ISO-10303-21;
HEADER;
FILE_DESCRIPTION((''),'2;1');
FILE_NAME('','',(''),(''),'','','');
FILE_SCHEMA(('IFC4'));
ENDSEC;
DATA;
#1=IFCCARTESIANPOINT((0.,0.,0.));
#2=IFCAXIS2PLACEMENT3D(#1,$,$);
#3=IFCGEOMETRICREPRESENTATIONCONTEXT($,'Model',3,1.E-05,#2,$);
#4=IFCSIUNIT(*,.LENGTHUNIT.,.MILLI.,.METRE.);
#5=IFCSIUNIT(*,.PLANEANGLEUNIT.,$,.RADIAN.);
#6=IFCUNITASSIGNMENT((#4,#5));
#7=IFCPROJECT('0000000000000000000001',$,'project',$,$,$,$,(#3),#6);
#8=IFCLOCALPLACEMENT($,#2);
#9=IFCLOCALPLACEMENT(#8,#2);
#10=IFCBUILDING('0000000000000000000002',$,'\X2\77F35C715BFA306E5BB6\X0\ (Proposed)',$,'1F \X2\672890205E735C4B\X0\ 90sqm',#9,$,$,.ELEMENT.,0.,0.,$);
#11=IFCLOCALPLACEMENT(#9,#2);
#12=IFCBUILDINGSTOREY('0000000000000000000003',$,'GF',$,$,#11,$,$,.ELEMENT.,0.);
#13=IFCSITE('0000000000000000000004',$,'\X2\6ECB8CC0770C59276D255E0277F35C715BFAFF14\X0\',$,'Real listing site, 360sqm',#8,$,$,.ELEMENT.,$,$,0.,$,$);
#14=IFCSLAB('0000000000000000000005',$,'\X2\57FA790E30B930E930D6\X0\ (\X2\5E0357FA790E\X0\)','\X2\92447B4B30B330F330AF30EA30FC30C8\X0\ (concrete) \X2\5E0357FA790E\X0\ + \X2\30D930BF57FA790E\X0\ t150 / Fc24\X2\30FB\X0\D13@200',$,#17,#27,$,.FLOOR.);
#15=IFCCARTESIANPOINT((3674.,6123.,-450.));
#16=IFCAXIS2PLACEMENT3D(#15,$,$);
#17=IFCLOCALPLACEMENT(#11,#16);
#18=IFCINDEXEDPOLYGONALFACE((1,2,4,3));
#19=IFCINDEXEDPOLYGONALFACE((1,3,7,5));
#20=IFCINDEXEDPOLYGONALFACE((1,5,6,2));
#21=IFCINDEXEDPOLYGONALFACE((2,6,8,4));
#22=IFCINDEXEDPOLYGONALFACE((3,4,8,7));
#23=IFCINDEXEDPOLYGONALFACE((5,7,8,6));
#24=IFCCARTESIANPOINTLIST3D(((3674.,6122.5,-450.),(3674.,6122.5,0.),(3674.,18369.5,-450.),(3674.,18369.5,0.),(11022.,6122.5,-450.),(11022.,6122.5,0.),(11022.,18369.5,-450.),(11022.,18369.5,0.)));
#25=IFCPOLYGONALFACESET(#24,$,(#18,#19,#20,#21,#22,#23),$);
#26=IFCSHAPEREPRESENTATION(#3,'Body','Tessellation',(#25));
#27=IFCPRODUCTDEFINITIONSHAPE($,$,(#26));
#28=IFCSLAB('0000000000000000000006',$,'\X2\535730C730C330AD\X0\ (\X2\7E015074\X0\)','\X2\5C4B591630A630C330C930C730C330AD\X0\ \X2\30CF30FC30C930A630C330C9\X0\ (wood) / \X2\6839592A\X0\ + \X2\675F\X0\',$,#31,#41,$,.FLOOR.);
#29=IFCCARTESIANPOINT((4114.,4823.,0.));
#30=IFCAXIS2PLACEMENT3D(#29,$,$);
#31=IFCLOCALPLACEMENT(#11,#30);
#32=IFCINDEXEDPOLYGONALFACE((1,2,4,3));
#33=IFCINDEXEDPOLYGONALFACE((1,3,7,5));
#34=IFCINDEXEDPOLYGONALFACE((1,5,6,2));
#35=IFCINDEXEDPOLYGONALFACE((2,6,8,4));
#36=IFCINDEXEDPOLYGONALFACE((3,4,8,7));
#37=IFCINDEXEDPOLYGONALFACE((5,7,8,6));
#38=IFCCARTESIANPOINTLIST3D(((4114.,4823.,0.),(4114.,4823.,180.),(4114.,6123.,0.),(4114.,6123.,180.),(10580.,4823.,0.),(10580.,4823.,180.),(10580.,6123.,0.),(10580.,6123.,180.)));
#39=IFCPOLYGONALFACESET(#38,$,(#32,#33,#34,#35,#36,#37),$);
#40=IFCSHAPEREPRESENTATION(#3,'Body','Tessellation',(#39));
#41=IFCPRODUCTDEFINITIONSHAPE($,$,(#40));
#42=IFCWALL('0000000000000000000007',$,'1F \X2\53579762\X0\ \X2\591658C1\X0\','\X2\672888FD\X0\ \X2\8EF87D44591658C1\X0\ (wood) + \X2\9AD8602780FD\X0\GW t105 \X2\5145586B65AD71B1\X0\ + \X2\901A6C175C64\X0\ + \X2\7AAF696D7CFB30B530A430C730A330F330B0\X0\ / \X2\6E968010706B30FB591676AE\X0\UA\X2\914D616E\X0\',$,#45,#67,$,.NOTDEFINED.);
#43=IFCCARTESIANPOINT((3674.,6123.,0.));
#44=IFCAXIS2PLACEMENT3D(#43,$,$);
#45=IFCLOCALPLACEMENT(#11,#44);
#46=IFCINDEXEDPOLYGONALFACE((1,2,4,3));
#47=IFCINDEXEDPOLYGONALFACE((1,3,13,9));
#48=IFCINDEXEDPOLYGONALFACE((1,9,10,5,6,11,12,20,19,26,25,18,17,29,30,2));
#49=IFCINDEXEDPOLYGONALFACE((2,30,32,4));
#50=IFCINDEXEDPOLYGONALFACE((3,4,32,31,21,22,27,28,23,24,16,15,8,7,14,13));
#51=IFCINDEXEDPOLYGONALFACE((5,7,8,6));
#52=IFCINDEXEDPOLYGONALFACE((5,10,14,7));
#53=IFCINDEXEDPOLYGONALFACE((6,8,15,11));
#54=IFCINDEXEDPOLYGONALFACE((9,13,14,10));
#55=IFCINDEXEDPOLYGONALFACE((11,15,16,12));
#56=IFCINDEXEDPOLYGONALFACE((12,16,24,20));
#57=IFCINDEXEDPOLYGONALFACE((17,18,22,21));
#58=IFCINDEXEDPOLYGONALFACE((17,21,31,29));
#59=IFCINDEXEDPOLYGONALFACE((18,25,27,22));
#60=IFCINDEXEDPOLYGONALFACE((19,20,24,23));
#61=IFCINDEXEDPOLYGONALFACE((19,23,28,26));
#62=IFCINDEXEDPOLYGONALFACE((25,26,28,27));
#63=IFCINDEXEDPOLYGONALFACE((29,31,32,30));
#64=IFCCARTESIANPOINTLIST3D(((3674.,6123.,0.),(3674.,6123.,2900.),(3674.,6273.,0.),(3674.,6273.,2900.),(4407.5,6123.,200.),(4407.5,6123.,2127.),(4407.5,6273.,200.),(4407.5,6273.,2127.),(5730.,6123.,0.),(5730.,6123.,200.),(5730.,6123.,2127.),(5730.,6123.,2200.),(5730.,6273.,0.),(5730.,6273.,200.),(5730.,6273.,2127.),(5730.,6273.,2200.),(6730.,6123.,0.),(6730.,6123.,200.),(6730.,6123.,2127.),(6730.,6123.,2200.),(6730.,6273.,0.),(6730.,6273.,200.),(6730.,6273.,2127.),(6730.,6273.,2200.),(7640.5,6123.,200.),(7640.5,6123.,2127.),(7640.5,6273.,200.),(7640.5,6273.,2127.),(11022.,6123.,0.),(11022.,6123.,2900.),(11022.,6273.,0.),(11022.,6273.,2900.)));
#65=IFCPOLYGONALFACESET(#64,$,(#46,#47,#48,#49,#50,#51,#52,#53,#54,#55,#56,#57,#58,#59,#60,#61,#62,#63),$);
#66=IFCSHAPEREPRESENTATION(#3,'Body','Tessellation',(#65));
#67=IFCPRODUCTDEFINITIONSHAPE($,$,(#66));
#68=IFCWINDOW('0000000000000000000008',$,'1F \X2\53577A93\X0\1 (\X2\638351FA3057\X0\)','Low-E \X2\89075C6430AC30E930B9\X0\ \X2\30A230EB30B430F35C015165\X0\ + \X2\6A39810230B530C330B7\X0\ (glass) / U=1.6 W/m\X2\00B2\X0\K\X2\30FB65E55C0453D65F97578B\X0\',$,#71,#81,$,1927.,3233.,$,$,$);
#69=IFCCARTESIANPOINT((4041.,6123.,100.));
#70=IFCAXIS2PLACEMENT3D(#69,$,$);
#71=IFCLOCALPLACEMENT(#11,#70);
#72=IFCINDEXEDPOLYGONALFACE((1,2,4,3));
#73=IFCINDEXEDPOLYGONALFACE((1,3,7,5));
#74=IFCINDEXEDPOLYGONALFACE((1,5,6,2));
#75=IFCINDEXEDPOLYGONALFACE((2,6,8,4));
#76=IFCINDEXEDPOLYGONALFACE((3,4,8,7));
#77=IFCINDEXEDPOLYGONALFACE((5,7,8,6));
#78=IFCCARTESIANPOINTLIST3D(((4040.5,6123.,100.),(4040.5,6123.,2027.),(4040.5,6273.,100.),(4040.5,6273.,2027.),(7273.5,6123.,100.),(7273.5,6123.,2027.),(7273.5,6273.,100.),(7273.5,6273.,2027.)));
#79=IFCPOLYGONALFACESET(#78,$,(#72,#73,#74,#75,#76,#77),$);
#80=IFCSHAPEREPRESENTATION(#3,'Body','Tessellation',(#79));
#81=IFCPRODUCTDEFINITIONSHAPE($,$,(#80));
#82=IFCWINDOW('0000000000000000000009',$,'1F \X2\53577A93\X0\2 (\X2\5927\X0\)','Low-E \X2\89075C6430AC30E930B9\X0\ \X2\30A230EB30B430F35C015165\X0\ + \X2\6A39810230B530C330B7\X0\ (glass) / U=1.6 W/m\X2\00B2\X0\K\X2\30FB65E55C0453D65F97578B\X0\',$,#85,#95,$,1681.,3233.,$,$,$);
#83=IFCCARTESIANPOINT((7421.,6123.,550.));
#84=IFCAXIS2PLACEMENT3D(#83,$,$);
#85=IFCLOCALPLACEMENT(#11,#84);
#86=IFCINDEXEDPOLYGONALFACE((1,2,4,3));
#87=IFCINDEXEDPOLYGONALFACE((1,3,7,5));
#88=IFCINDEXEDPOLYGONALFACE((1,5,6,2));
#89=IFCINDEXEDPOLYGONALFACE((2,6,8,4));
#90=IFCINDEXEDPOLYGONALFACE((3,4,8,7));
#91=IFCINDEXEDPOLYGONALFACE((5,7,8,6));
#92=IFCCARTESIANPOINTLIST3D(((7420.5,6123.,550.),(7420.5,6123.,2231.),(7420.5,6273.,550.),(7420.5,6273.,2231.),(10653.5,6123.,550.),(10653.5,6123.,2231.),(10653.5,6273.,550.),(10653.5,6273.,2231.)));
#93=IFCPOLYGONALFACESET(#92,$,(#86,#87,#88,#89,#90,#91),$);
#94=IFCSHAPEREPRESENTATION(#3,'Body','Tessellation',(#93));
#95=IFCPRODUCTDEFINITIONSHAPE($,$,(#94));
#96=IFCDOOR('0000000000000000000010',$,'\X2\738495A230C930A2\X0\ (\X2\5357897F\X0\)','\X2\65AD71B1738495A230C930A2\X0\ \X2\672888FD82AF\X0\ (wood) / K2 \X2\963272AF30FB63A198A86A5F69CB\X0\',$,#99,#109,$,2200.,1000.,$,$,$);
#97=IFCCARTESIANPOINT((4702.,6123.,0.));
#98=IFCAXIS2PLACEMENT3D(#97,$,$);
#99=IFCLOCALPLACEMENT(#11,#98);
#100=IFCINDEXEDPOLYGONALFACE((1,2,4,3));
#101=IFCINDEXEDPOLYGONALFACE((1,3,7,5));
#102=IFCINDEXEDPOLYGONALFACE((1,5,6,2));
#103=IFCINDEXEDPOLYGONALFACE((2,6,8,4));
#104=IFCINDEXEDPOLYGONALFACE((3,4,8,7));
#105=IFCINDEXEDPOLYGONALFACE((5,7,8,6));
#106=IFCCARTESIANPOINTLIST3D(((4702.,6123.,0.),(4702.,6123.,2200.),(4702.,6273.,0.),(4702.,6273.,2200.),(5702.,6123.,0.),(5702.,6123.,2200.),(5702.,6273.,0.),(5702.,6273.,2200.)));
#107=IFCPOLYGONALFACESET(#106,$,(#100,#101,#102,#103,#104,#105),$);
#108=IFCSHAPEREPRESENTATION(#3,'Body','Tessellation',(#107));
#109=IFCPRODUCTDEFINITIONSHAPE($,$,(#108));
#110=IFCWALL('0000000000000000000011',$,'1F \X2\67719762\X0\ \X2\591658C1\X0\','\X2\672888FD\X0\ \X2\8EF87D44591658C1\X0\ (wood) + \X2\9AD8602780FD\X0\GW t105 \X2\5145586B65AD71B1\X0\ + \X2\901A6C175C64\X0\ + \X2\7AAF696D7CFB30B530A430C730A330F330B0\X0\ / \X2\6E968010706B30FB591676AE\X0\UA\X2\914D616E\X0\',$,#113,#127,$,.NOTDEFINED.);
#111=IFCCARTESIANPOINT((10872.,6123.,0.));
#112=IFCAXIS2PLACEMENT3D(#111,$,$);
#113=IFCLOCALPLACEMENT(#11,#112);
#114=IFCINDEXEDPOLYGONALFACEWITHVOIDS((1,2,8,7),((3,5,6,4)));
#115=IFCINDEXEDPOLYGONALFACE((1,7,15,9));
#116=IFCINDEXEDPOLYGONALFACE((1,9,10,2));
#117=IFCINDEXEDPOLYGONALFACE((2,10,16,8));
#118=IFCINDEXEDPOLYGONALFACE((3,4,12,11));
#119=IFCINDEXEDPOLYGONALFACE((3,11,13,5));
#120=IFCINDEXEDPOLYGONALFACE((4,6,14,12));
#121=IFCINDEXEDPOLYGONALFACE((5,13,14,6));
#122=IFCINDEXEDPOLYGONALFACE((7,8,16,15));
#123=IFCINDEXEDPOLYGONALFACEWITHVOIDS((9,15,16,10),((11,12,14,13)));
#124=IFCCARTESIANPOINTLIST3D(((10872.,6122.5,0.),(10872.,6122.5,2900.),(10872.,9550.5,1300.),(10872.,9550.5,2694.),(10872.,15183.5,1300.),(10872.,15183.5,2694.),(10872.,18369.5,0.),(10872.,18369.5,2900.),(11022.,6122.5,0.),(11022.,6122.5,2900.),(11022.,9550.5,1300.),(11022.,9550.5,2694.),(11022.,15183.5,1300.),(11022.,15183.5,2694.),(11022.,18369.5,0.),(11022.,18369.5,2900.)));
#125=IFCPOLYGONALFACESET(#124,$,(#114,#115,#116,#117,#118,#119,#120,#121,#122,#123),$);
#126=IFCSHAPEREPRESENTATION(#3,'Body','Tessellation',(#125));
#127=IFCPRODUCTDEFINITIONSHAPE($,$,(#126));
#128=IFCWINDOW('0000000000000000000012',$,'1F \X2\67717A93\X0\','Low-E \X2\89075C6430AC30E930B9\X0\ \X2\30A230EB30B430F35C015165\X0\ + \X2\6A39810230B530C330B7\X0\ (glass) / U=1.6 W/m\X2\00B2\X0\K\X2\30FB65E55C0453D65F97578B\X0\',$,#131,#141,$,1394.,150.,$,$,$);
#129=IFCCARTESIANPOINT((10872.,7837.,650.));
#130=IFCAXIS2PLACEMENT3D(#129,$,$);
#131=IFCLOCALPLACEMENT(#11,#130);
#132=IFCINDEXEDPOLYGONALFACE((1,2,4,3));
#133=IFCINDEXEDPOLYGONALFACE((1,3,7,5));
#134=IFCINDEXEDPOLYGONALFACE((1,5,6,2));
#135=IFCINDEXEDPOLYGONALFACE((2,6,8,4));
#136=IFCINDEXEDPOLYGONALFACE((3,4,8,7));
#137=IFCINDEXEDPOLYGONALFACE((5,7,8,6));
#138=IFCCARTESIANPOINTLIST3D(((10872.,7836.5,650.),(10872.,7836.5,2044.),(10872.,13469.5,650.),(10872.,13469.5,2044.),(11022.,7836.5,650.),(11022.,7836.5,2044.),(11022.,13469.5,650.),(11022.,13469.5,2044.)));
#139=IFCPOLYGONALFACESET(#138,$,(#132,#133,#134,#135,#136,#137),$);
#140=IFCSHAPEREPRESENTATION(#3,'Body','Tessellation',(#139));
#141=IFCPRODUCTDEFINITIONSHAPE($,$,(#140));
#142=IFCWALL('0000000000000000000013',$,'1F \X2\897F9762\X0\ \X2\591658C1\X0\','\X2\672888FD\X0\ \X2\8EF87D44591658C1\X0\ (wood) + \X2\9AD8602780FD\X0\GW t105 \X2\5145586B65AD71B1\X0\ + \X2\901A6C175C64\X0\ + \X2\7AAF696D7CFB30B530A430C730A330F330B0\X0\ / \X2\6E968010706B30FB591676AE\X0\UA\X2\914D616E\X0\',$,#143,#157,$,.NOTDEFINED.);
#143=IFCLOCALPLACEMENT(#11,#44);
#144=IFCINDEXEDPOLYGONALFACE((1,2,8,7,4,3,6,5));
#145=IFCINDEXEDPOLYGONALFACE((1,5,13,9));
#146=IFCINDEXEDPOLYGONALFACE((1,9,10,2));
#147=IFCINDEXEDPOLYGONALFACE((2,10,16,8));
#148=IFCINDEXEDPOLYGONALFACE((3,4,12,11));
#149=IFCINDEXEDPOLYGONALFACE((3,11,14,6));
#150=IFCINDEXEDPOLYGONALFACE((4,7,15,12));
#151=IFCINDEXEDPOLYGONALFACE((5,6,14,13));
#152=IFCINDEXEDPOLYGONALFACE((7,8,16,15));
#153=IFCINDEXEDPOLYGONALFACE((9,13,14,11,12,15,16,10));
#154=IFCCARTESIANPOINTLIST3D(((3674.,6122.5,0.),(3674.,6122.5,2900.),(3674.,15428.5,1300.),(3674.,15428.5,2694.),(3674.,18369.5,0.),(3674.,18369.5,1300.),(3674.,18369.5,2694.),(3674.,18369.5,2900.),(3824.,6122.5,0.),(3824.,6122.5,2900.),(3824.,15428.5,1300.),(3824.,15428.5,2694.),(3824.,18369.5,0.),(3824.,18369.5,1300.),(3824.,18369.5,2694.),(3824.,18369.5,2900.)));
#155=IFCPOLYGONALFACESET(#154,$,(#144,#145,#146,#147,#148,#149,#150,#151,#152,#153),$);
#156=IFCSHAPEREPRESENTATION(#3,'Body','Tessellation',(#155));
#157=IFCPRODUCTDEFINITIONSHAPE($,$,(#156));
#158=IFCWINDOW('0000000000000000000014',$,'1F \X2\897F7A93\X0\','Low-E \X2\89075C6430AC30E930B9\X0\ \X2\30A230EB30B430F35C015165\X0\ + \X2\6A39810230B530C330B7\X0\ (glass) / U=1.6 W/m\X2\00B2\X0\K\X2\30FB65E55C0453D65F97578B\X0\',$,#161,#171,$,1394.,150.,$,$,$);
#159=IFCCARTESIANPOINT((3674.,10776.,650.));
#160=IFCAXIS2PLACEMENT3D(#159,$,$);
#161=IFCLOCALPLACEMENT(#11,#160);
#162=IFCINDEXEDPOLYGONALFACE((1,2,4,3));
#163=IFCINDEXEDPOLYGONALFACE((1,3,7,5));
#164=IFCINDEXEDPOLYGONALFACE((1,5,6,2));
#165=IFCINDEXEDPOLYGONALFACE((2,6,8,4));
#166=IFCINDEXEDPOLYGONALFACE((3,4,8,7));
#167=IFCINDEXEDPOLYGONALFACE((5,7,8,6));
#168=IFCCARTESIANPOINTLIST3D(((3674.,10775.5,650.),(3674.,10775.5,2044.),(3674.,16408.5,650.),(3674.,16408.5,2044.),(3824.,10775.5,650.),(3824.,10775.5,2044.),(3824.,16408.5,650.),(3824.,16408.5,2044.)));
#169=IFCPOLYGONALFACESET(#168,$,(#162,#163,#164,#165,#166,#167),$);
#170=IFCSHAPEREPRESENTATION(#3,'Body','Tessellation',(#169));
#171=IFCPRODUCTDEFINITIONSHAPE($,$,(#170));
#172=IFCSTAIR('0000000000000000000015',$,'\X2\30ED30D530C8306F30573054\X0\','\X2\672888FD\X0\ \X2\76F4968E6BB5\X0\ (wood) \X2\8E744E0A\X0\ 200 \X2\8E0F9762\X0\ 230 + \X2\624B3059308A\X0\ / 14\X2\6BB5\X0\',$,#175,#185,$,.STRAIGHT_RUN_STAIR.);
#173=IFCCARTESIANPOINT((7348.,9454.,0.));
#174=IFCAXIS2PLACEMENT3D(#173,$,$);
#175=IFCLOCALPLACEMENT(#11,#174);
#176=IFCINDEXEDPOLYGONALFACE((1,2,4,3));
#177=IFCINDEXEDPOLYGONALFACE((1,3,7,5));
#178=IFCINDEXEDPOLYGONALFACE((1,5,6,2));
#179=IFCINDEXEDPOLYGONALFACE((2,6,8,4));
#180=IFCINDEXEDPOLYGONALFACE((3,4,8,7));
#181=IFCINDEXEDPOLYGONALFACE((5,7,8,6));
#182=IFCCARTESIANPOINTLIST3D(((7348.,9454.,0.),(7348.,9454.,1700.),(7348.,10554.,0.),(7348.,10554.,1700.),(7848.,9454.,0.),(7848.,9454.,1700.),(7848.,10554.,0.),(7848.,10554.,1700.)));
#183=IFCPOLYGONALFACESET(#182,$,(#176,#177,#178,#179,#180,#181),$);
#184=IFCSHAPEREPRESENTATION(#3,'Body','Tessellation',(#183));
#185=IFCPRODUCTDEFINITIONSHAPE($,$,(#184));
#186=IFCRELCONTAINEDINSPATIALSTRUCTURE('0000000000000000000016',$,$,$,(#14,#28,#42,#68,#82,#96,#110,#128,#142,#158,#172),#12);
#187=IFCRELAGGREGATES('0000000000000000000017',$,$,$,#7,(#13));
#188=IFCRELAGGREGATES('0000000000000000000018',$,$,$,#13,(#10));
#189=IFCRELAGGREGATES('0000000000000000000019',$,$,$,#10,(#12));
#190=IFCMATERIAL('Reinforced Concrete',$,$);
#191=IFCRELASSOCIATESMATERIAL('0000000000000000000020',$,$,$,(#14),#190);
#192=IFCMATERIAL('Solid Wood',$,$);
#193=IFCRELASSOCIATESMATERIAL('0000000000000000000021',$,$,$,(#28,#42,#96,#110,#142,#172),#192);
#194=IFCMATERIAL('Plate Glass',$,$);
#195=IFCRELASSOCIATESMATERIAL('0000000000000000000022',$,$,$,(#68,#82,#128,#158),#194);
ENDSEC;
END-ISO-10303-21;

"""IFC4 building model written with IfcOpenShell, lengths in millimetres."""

from ifc_helpers import new_model, si_unit, frame, frame_2d, origin, place, context, project, spatial, rectangle, extrude, material, element, fill, save


model = new_model("IFC4")

# Units and contexts
model_context = context("Model", 3, precision=1e-05, world=origin())
ifc_project = project(units=[si_unit("LENGTHUNIT", "METRE", prefix="MILLI"), si_unit("PLANEANGLEUNIT", "RADIAN")], contexts=[model_context])

# Site, building, storey
site_placement = place(None, origin())
site = spatial("IfcSite", under=ifc_project, at=site_placement, Name="滋賀県大津市石山寺４", ObjectType="Real listing site, 360sqm", CompositionType="ELEMENT", RefElevation=0.0)
building_placement = place(site_placement, origin())
building = spatial("IfcBuilding", under=site, at=building_placement, Name="石山寺の家 (Proposed)", ObjectType="1F 木造平屋 90sqm", CompositionType="ELEMENT", ElevationOfRefHeight=0.0, ElevationOfTerrain=0.0)
storey_placement = place(building_placement, origin())
storey = spatial("IfcBuildingStorey", under=building, at=storey_placement, Name="GF", CompositionType="ELEMENT", Elevation=0.0)

# Slabs
ifc_material_1 = material(Name="Reinforced Concrete")
slab_1_placement = place(storey_placement, frame((3674.0, 6123.0, -450.0)))
element("IfcSlab", 1, at=slab_1_placement, inside=storey, material=ifc_material_1, Name="基礎スラブ (布基礎)", Description="鉄筋コンクリート (concrete) 布基礎 + ベタ基礎 t150 / Fc24・D13@200", PredefinedType="FLOOR", context=model_context, shape_type="SweptSolid", body=[
    extrude(rectangle(XDim=7348.0, YDim=12247.0, at=frame_2d((3674.0, 6123.0))), frame((3674.0, 6123.0, -450.0)), (0.0, 0.0, 1.0), 450.0),
])
ifc_material_2 = material(Name="Solid Wood")
slab_2_placement = place(storey_placement, frame((4114.0, 4823.0, 0.0)))
element("IfcSlab", 2, at=slab_2_placement, inside=storey, material=ifc_material_2, Name="南デッキ (縁側)", Description="屋外ウッドデッキ ハードウッド (wood) / 根太 + 束", PredefinedType="FLOOR", context=model_context, shape_type="SweptSolid", body=[
    extrude(rectangle(XDim=6466.0, YDim=1300.0, at=frame_2d((3233.0, 650.0))), frame((4114.0, 4823.0, 0.0)), (0.0, 0.0, 1.0), 180.0),
])

# Wall, openings, windows, door
wall_1_placement = place(storey_placement, frame((3674.0, 6123.0, 0.0)))
wall_1 = element("IfcWall", 3, at=wall_1_placement, inside=storey, material=ifc_material_2, Name="1F 南面 外壁", Description="木製 軸組外壁 (wood) + 高性能GW t105 充填断熱 + 通気層 + 窯業系サイディング / 準耐火・外皮UA配慮", PredefinedType="NOTDEFINED", context=model_context, shape_type="SweptSolid", body=[
    extrude(rectangle(XDim=7348.0, YDim=150.0, at=frame_2d((3674.0, 75.0))), frame((3674.0, 6123.0, 0.0)), (0.0, 0.0, 1.0), 2900.0),
])
opening_1_placement = place(storey_placement, frame((4041.0, 6123.0, 100.0)))
opening_1 = element("IfcOpeningElement", 4, at=opening_1_placement, cuts=wall_1, PredefinedType="NOTDEFINED", context=model_context, shape_type="SweptSolid", body=[
    extrude(rectangle(XDim=3233.0, YDim=150.0, at=frame_2d((1616.0, 75.0))), frame((4041.0, 6123.0, 100.0)), (0.0, 0.0, 1.0), 1927.0),
])
opening_2_placement = place(storey_placement, frame((7421.0, 6123.0, 550.0)))
opening_2 = element("IfcOpeningElement", 5, at=opening_2_placement, cuts=wall_1, PredefinedType="NOTDEFINED", context=model_context, shape_type="SweptSolid", body=[
    extrude(rectangle(XDim=3233.0, YDim=150.0, at=frame_2d((1616.0, 75.0))), frame((7421.0, 6123.0, 550.0)), (0.0, 0.0, 1.0), 1681.0),
])
opening_3_placement = place(storey_placement, frame((4702.0, 6123.0, 0.0)))
opening_3 = element("IfcOpeningElement", 6, at=opening_3_placement, cuts=wall_1, PredefinedType="NOTDEFINED", context=model_context, shape_type="SweptSolid", body=[
    extrude(rectangle(XDim=1000.0, YDim=150.0, at=frame_2d((500.0, 75.0))), frame((4702.0, 6123.0, 0.0)), (0.0, 0.0, 1.0), 2200.0),
])
ifc_material_3 = material(Name="Plate Glass")
window_1_placement = place(storey_placement, frame((4041.0, 6123.0, 100.0)))
window_1 = element("IfcWindow", 7, at=window_1_placement, inside=storey, material=ifc_material_3, Name="1F 南窓1 (掃出し)", Description="Low-E 複層ガラス アルゴン封入 + 樹脂サッシ (glass) / U=1.6 W/m²K・日射取得型", OverallHeight=1927.0, OverallWidth=3233.0, context=model_context, shape_type="SweptSolid", body=[
    extrude(rectangle(XDim=3233.0, YDim=150.0, at=frame_2d((1616.0, 75.0))), frame((4041.0, 6123.0, 100.0)), (0.0, 0.0, 1.0), 1927.0),
])
fill(opening_1, window_1)
window_2_placement = place(storey_placement, frame((7421.0, 6123.0, 550.0)))
window_2 = element("IfcWindow", 8, at=window_2_placement, inside=storey, material=ifc_material_3, Name="1F 南窓2 (大)", Description="Low-E 複層ガラス アルゴン封入 + 樹脂サッシ (glass) / U=1.6 W/m²K・日射取得型", OverallHeight=1681.0, OverallWidth=3233.0, context=model_context, shape_type="SweptSolid", body=[
    extrude(rectangle(XDim=3233.0, YDim=150.0, at=frame_2d((1616.0, 75.0))), frame((7421.0, 6123.0, 550.0)), (0.0, 0.0, 1.0), 1681.0),
])
fill(opening_2, window_2)
door_placement = place(storey_placement, frame((4702.0, 6123.0, 0.0)))
door = element("IfcDoor", 9, at=door_placement, inside=storey, material=ifc_material_2, Name="玄関ドア (南西)", Description="断熱玄関ドア 木製芯 (wood) / K2 防犯・採風機構", OverallHeight=2200.0, OverallWidth=1000.0, context=model_context, shape_type="SweptSolid", body=[
    extrude(rectangle(XDim=1000.0, YDim=150.0, at=frame_2d((500.0, 75.0))), frame((4702.0, 6123.0, 0.0)), (0.0, 0.0, 1.0), 2200.0),
])
fill(opening_3, door)

# Walls, openings, windows
wall_2_placement = place(storey_placement, frame((10872.0, 6123.0, 0.0)))
wall_2 = element("IfcWall", 10, at=wall_2_placement, inside=storey, material=ifc_material_2, Name="1F 東面 外壁", Description="木製 軸組外壁 (wood) + 高性能GW t105 充填断熱 + 通気層 + 窯業系サイディング / 準耐火・外皮UA配慮", PredefinedType="NOTDEFINED", context=model_context, shape_type="SweptSolid", body=[
    extrude(rectangle(XDim=150.0, YDim=12247.0, at=frame_2d((75.0, 6123.0))), frame((10872.0, 6123.0, 0.0)), (0.0, 0.0, 1.0), 2900.0),
])
opening_4_placement = place(storey_placement, frame((10872.0, 7837.0, 650.0)))
opening_4 = element("IfcOpeningElement", 11, at=opening_4_placement, cuts=wall_2, PredefinedType="NOTDEFINED", context=model_context, shape_type="SweptSolid", body=[
    extrude(rectangle(XDim=150.0, YDim=5633.0, at=frame_2d((75.0, 2816.0))), frame((10872.0, 7837.0, 650.0)), (0.0, 0.0, 1.0), 1394.0),
])
window_3_placement = place(storey_placement, frame((10872.0, 7837.0, 650.0)))
window_3 = element("IfcWindow", 12, at=window_3_placement, inside=storey, material=ifc_material_3, Name="1F 東窓", Description="Low-E 複層ガラス アルゴン封入 + 樹脂サッシ (glass) / U=1.6 W/m²K・日射取得型", OverallHeight=1394.0, OverallWidth=150.0, context=model_context, shape_type="SweptSolid", body=[
    extrude(rectangle(XDim=150.0, YDim=5633.0, at=frame_2d((75.0, 2816.0))), frame((10872.0, 7837.0, 650.0)), (0.0, 0.0, 1.0), 1394.0),
])
fill(opening_4, window_3)
wall_3_placement = place(storey_placement, frame((3674.0, 6123.0, 0.0)))
wall_3 = element("IfcWall", 13, at=wall_3_placement, inside=storey, material=ifc_material_2, Name="1F 西面 外壁", Description="木製 軸組外壁 (wood) + 高性能GW t105 充填断熱 + 通気層 + 窯業系サイディング / 準耐火・外皮UA配慮", PredefinedType="NOTDEFINED", context=model_context, shape_type="SweptSolid", body=[
    extrude(rectangle(XDim=150.0, YDim=12247.0, at=frame_2d((75.0, 6123.0))), frame((3674.0, 6123.0, 0.0)), (0.0, 0.0, 1.0), 2900.0),
])
opening_5_placement = place(storey_placement, frame((3674.0, 10776.0, 650.0)))
opening_5 = element("IfcOpeningElement", 14, at=opening_5_placement, cuts=wall_3, PredefinedType="NOTDEFINED", context=model_context, shape_type="SweptSolid", body=[
    extrude(rectangle(XDim=150.0, YDim=5633.0, at=frame_2d((75.0, 2816.0))), frame((3674.0, 10776.0, 650.0)), (0.0, 0.0, 1.0), 1394.0),
])
window_4_placement = place(storey_placement, frame((3674.0, 10776.0, 650.0)))
window_4 = element("IfcWindow", 15, at=window_4_placement, inside=storey, material=ifc_material_3, Name="1F 西窓", Description="Low-E 複層ガラス アルゴン封入 + 樹脂サッシ (glass) / U=1.6 W/m²K・日射取得型", OverallHeight=1394.0, OverallWidth=150.0, context=model_context, shape_type="SweptSolid", body=[
    extrude(rectangle(XDim=150.0, YDim=5633.0, at=frame_2d((75.0, 2816.0))), frame((3674.0, 10776.0, 650.0)), (0.0, 0.0, 1.0), 1394.0),
])
fill(opening_5, window_4)

# Stair
stair_placement = place(storey_placement, frame((7348.0, 9454.0, 0.0)))
element("IfcStair", 16, at=stair_placement, inside=storey, material=ifc_material_2, Name="ロフトはしご", Description="木製 直階段 (wood) 蹴上 200 踏面 230 + 手すり / 14段", PredefinedType="STRAIGHT_RUN_STAIR", context=model_context, shape_type="SweptSolid", body=[
    extrude(rectangle(XDim=500.0, YDim=1100.0, at=frame_2d((250.0, 550.0))), frame((7348.0, 9454.0, 0.0)), (0.0, 0.0, 1.0), 1700.0),
])

save(model, "model.ifc")
